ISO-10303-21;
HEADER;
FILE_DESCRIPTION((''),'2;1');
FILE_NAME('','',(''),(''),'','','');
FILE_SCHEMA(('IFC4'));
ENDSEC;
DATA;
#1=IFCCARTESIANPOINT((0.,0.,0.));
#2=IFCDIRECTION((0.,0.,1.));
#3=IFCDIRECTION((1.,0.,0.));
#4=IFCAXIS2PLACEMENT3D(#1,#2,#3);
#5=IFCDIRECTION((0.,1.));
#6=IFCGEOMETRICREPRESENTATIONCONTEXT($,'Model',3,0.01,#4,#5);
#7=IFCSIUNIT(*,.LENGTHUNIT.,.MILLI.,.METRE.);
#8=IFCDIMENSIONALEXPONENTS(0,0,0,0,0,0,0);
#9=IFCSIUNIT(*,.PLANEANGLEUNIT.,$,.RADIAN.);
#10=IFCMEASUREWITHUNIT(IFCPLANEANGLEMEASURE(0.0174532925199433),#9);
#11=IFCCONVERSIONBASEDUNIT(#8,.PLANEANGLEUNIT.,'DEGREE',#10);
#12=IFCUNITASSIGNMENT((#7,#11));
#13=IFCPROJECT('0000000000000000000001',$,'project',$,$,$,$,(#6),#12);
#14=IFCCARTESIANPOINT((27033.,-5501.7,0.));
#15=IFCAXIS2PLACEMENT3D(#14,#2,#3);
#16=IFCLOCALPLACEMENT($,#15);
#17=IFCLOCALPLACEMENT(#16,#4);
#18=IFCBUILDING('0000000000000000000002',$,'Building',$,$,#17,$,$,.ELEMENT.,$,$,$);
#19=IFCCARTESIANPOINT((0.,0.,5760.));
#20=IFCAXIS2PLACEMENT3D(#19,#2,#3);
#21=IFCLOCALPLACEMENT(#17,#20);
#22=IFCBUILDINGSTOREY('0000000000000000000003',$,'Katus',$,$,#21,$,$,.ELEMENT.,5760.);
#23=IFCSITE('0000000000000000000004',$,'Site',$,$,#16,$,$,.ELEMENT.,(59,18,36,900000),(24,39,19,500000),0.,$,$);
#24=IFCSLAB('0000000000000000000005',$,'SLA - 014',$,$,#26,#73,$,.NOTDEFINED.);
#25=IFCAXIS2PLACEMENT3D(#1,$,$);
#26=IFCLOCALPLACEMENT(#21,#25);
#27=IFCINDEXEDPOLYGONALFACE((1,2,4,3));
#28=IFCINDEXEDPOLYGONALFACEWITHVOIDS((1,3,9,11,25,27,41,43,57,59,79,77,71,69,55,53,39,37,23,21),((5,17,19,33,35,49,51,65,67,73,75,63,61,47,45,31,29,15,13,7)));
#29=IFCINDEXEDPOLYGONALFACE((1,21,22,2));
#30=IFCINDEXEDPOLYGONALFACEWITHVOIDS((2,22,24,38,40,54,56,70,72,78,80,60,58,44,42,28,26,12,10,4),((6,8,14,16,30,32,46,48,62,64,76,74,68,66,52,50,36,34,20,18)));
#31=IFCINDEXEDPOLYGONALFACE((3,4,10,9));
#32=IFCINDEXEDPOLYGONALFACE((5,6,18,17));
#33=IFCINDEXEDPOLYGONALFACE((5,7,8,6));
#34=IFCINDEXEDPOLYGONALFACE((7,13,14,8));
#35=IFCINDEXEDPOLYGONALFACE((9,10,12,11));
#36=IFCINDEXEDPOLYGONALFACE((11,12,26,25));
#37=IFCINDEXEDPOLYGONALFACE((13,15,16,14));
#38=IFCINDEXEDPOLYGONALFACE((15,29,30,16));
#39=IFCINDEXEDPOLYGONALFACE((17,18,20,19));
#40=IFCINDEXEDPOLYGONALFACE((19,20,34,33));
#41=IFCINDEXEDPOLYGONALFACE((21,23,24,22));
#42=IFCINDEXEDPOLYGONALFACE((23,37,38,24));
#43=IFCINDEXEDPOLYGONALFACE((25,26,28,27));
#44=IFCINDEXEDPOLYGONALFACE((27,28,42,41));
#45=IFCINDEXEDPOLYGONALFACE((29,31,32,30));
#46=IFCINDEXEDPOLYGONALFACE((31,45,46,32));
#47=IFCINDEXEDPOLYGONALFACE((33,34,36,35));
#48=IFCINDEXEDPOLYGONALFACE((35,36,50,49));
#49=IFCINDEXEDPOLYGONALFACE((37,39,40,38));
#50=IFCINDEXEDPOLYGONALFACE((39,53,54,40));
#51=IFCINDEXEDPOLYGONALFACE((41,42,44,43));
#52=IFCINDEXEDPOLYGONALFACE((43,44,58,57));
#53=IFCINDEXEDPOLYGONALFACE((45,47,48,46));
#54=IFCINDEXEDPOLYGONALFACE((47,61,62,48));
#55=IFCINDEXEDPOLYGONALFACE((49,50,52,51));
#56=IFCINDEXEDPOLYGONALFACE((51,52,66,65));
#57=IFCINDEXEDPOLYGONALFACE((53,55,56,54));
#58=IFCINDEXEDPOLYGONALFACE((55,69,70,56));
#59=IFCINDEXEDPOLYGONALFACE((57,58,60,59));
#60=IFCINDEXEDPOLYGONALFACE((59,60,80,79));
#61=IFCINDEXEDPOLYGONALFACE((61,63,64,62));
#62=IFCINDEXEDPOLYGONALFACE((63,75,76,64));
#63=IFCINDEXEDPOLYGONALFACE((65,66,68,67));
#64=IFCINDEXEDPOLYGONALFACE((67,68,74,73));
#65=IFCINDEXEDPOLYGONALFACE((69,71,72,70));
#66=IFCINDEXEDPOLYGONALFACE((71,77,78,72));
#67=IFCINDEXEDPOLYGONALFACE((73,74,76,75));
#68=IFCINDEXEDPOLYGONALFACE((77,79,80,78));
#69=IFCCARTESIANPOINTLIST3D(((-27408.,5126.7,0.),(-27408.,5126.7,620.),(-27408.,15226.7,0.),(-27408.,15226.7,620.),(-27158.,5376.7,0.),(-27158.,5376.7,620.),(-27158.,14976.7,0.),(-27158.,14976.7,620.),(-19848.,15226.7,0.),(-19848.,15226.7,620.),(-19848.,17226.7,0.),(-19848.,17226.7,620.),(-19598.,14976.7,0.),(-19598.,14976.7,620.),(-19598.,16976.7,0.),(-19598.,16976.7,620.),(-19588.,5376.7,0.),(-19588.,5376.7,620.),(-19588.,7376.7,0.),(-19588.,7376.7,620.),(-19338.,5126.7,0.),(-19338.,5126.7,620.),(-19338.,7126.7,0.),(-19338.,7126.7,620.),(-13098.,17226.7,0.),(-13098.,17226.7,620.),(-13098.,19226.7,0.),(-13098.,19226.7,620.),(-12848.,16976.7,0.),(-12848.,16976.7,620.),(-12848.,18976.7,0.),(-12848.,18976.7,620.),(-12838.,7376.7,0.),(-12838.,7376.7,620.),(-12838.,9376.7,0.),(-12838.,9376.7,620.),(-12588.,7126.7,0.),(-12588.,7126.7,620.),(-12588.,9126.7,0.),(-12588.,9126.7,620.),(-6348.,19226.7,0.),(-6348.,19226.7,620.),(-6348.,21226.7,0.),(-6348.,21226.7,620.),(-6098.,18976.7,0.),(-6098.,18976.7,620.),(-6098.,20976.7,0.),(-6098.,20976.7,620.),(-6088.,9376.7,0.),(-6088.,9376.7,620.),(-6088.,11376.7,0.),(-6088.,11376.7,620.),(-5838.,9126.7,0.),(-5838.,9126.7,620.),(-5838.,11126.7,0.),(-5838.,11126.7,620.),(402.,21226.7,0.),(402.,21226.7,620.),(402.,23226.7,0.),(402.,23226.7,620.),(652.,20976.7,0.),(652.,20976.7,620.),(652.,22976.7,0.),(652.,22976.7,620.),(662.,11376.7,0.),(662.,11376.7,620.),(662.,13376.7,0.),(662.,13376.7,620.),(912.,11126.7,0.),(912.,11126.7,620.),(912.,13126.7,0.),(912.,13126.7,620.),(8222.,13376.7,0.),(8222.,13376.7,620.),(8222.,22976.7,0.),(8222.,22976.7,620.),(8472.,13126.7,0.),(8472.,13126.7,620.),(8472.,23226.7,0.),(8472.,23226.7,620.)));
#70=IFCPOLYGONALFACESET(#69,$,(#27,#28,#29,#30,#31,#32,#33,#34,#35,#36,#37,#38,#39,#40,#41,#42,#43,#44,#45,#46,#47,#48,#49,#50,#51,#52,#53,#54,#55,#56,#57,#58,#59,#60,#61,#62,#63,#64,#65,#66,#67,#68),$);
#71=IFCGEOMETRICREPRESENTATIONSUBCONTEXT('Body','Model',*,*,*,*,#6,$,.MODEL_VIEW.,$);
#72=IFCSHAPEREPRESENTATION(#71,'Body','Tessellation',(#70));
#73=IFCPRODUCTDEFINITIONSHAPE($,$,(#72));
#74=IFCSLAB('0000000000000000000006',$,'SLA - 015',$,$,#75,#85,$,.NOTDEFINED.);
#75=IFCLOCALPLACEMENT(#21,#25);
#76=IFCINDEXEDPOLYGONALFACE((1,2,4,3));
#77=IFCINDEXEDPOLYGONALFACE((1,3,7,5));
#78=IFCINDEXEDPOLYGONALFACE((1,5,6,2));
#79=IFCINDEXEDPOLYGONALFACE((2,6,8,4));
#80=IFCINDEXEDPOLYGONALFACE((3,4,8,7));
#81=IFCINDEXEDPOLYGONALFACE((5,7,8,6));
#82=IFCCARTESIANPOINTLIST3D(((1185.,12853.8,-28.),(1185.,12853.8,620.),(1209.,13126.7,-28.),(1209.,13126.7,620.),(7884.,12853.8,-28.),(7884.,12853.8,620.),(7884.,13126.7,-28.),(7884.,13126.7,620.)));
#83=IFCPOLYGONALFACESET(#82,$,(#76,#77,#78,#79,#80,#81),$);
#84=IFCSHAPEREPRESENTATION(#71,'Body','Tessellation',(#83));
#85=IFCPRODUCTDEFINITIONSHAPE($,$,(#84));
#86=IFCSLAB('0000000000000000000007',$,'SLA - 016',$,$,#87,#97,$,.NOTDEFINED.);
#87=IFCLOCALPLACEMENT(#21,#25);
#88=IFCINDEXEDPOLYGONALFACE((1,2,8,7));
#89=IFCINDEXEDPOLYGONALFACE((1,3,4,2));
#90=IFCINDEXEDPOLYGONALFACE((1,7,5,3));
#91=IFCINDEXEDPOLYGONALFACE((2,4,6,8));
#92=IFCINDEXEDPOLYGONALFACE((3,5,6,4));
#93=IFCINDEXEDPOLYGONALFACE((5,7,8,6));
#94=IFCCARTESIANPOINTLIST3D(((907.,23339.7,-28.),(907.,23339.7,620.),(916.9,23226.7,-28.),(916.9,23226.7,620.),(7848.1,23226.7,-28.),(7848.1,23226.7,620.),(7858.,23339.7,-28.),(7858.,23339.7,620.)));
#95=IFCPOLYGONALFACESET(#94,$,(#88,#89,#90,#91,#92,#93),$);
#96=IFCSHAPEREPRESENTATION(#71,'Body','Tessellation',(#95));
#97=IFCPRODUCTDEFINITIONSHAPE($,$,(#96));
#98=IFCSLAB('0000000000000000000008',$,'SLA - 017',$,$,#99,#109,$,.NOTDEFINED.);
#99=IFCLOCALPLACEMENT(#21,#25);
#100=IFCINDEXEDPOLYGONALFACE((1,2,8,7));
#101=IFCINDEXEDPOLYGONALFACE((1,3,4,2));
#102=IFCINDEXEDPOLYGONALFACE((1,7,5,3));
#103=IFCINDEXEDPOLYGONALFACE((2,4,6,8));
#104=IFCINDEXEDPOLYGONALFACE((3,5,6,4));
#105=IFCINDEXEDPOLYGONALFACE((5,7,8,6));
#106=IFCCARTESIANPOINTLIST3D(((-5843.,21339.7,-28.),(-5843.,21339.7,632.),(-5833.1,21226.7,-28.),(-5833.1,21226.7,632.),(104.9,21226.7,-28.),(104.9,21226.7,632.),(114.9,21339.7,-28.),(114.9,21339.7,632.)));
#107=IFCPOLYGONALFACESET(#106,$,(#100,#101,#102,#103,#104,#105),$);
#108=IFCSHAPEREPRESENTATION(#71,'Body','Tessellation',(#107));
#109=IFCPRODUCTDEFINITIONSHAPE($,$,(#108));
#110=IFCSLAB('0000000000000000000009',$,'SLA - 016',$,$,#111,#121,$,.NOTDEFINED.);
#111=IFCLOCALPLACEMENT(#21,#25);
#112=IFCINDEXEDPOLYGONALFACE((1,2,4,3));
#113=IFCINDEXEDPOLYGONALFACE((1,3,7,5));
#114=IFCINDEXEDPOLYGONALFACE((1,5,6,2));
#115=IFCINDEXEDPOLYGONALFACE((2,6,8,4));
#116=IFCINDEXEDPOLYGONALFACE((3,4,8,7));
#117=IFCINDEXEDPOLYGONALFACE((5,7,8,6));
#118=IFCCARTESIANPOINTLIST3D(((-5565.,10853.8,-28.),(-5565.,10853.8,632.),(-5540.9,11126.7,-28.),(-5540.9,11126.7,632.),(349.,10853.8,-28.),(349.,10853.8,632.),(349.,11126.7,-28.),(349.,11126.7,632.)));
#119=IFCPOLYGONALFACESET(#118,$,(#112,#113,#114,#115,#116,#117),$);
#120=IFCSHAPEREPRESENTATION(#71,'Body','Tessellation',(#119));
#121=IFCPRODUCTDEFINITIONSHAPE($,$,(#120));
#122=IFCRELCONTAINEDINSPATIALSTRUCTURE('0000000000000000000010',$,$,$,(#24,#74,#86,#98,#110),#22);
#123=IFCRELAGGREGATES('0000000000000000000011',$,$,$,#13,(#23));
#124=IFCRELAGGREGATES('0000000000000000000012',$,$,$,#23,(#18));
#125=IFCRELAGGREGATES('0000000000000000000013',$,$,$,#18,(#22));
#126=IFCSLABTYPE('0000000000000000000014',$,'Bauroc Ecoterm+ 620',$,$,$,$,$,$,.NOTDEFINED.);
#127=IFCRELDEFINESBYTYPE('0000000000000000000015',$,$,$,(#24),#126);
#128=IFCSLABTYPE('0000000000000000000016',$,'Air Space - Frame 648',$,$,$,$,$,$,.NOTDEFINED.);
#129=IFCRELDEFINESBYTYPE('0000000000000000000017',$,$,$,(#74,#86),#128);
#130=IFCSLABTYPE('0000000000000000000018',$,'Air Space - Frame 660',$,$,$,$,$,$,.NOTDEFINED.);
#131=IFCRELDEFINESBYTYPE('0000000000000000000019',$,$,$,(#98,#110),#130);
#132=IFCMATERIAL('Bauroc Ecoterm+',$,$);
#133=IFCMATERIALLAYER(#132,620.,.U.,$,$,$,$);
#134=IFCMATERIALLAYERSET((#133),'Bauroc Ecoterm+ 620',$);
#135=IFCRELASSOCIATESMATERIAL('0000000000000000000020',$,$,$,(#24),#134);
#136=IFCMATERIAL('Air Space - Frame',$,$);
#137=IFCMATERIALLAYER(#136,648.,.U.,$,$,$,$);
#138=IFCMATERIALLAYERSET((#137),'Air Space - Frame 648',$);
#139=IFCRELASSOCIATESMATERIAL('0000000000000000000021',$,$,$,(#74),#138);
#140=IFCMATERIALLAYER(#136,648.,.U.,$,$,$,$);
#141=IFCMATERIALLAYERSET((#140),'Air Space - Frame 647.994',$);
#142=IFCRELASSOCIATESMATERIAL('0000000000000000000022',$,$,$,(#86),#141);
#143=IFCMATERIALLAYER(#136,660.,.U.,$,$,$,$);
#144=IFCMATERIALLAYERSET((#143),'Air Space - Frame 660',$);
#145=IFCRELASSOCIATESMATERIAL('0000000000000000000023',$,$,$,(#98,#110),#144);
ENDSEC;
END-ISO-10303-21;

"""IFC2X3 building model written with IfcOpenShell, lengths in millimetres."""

from ifc_helpers import new_model, entity, si_unit, converted_unit, direction, frame, origin_with_axes, place, context, subcontext, project, spatial, polyline, outline, extrude, material, layer, layer_set, layer_usage, type_object, element, save


model = new_model("IFC2X3")

# Units and contexts
model_context = context("Model", 3, precision=0.01, world=origin_with_axes(), true_north=direction((0.0, 1.0)))
body_context = subcontext(model_context, "Body", "Model", "MODEL_VIEW")
ifc_project = project(units=[si_unit("LENGTHUNIT", "METRE", prefix="MILLI"), converted_unit("PLANEANGLEUNIT", "DEGREE", entity("IfcPlaneAngleMeasure", 0.0174532925199433), si_unit("PLANEANGLEUNIT", "RADIAN"), dimensions=[0, 0, 0, 0, 0, 0, 0])], contexts=[model_context])

# Site, building, storey
site_placement = place(None, frame((27033.0, -5501.7, 0.0), z_axis=(0.0, 0.0, 1.0), x_axis=(1.0, 0.0, 0.0)))
site = spatial("IfcSite", under=ifc_project, at=site_placement, Name="Site", CompositionType="ELEMENT", RefLatitude=(59, 18, 36, 900000), RefLongitude=(24, 39, 19, 500000), RefElevation=0.0)
building_placement = place(site_placement, origin_with_axes())
building = spatial("IfcBuilding", under=site, at=building_placement, Name="Building", CompositionType="ELEMENT")
storey_placement = place(building_placement, frame((0.0, 0.0, 5760.0), z_axis=(0.0, 0.0, 1.0), x_axis=(1.0, 0.0, 0.0)))
storey = spatial("IfcBuildingStorey", under=building, at=storey_placement, Name="Katus", CompositionType="ELEMENT", Elevation=5760.0)

# Slabs
ifc_material_1 = material(Name="Bauroc Ecoterm+")
ifc_layer_1 = layer(ifc_material_1, 620.0, ventilated="UNKNOWN")
ifc_layer_set_1 = layer_set([ifc_layer_1], Name="Bauroc Ecoterm+ 620")
ifc_layer_usage_1 = layer_usage(ifc_layer_set_1, "AXIS3", "NEGATIVE", 620.0)
slab_type_1 = type_object("IfcSlabType", Name="Bauroc Ecoterm+ 620", PredefinedType="NOTDEFINED")
slab_1_placement = place(storey_placement, frame((912.0, 13126.7, 0.0), z_axis=(0.0, 0.0, 1.0), x_axis=(1.0, 0.0, 0.0)))
element("IfcSlab", 1, at=slab_1_placement, inside=storey, type_object=slab_type_1, material=ifc_layer_usage_1, Name="SLA - 014", PredefinedType="NOTDEFINED", context=body_context, shape_type="SweptSolid", body=[
    extrude(outline(polyline([(0.0, 0.0), (7560.0, 0.0), (7560.0, 10100.0), (-510.0, 10100.0), (-510.0, 8100.0), (-7260.0, 8100.0), (-7260.0, 6100.0), (-14010.0, 6100.0), (-14010.0, 4100.0), (-20760.0, 4100.0), (-20760.0, 2100.0), (-28320.0, 2100.0), (-28320.0, -8000.0), (-20250.0, -8000.0), (-20250.0, -6000.0), (-13500.0, -6000.0), (-13500.0, -4000.0), (-6750.0, -4000.0), (-6750.0, -2000.0), (0.0, -2000.0), (0.0, 0.0)]), holes=[polyline([(7310.0, 9850.0), (7310.0, 250.0), (-250.0, 250.0), (-250.0, -1750.0), (-7000.0, -1750.0), (-7000.0, -3750.0), (-13750.0, -3750.0), (-13750.0, -5750.0), (-20500.0, -5750.0), (-20500.0, -7750.0), (-28070.0, -7750.0), (-28070.0, 1850.0), (-20510.0, 1850.0), (-20510.0, 3850.0), (-13760.0, 3850.0), (-13760.0, 5850.0), (-7010.0, 5850.0), (-7010.0, 7850.0), (-260.0, 7850.0), (-260.0, 9850.0), (7310.0, 9850.0)])]), origin_with_axes(), (0.0, 0.0, 1.0), 620.0),
])
ifc_material_2 = material(Name="Air Space - Frame")
ifc_layer_2 = layer(ifc_material_2, 648.0, ventilated="UNKNOWN")
ifc_layer_set_2 = layer_set([ifc_layer_2], Name="Air Space - Frame 648")
ifc_layer_usage_2 = layer_usage(ifc_layer_set_2, "AXIS3", "NEGATIVE", 648.0)
slab_type_2 = type_object("IfcSlabType", Name="Air Space - Frame 648", PredefinedType="NOTDEFINED")
slab_2_placement = place(storey_placement, frame((1185.0, 12853.8, -28.0), z_axis=(0.0, 0.0, 1.0), x_axis=(1.0, 0.0, 0.0)))
element("IfcSlab", 2, at=slab_2_placement, inside=storey, type_object=slab_type_2, material=ifc_layer_usage_2, Name="SLA - 015", PredefinedType="NOTDEFINED", context=body_context, shape_type="SweptSolid", body=[
    extrude(outline(polyline([(0.0, 0.0), (6699.0, 0.0), (6699.0, 272.9), (24.0, 272.9), (0.0, 0.0)])), origin_with_axes(), (0.0, 0.0, 1.0), 648.0),
])
ifc_layer_3 = layer(ifc_material_2, 648.0, ventilated="UNKNOWN")
ifc_layer_set_3 = layer_set([ifc_layer_3], Name="Air Space - Frame 647.994")
ifc_layer_usage_3 = layer_usage(ifc_layer_set_3, "AXIS3", "NEGATIVE", 648.0)
slab_3_placement = place(storey_placement, frame((916.9, 23226.7, -28.0), z_axis=(0.0, 0.0, 1.0), x_axis=(1.0, 0.0, 0.0)))
element("IfcSlab", 3, at=slab_3_placement, inside=storey, type_object=slab_type_2, material=ifc_layer_usage_3, Name="SLA - 016", PredefinedType="NOTDEFINED", context=body_context, shape_type="SweptSolid", body=[
    extrude(outline(polyline([(0.0, 0.0), (6931.2, 0.0), (6941.1, 113.0), (-9.9, 113.0), (0.0, 0.0)])), origin_with_axes(), (0.0, 0.0, 1.0), 648.0),
])
ifc_layer_4 = layer(ifc_material_2, 660.0, ventilated="UNKNOWN")
ifc_layer_set_4 = layer_set([ifc_layer_4], Name="Air Space - Frame 660")
ifc_layer_usage_4 = layer_usage(ifc_layer_set_4, "AXIS3", "NEGATIVE", 660.0)
slab_type_3 = type_object("IfcSlabType", Name="Air Space - Frame 660", PredefinedType="NOTDEFINED")
slab_4_placement = place(storey_placement, frame((114.9, 21339.7, -28.0), z_axis=(0.0, 0.0, 1.0), x_axis=(1.0, 0.0, 0.0)))
element("IfcSlab", 4, at=slab_4_placement, inside=storey, type_object=slab_type_3, material=ifc_layer_usage_4, Name="SLA - 017", PredefinedType="NOTDEFINED", context=body_context, shape_type="SweptSolid", body=[
    extrude(outline(polyline([(0.0, 0.0), (-5957.9, 0.0), (-5948.0, -113.0), (-9.9, -113.0), (0.0, 0.0)])), origin_with_axes(), (0.0, 0.0, 1.0), 660.0),
])
ifc_layer_usage_5 = layer_usage(ifc_layer_set_4, "AXIS3", "NEGATIVE", 660.0)
slab_5_placement = place(storey_placement, frame((349.0, 10853.8, -28.0), z_axis=(0.0, 0.0, 1.0), x_axis=(1.0, 0.0, 0.0)))
element("IfcSlab", 5, at=slab_5_placement, inside=storey, type_object=slab_type_3, material=ifc_layer_usage_5, Name="SLA - 016", PredefinedType="NOTDEFINED", context=body_context, shape_type="SweptSolid", body=[
    extrude(outline(polyline([(0.0, 0.0), (0.0, 272.9), (-5889.9, 272.9), (-5913.9, 0.0), (0.0, 0.0)])), origin_with_axes(), (0.0, 0.0, 1.0), 660.0),
])

save(model, "model.ifc")
